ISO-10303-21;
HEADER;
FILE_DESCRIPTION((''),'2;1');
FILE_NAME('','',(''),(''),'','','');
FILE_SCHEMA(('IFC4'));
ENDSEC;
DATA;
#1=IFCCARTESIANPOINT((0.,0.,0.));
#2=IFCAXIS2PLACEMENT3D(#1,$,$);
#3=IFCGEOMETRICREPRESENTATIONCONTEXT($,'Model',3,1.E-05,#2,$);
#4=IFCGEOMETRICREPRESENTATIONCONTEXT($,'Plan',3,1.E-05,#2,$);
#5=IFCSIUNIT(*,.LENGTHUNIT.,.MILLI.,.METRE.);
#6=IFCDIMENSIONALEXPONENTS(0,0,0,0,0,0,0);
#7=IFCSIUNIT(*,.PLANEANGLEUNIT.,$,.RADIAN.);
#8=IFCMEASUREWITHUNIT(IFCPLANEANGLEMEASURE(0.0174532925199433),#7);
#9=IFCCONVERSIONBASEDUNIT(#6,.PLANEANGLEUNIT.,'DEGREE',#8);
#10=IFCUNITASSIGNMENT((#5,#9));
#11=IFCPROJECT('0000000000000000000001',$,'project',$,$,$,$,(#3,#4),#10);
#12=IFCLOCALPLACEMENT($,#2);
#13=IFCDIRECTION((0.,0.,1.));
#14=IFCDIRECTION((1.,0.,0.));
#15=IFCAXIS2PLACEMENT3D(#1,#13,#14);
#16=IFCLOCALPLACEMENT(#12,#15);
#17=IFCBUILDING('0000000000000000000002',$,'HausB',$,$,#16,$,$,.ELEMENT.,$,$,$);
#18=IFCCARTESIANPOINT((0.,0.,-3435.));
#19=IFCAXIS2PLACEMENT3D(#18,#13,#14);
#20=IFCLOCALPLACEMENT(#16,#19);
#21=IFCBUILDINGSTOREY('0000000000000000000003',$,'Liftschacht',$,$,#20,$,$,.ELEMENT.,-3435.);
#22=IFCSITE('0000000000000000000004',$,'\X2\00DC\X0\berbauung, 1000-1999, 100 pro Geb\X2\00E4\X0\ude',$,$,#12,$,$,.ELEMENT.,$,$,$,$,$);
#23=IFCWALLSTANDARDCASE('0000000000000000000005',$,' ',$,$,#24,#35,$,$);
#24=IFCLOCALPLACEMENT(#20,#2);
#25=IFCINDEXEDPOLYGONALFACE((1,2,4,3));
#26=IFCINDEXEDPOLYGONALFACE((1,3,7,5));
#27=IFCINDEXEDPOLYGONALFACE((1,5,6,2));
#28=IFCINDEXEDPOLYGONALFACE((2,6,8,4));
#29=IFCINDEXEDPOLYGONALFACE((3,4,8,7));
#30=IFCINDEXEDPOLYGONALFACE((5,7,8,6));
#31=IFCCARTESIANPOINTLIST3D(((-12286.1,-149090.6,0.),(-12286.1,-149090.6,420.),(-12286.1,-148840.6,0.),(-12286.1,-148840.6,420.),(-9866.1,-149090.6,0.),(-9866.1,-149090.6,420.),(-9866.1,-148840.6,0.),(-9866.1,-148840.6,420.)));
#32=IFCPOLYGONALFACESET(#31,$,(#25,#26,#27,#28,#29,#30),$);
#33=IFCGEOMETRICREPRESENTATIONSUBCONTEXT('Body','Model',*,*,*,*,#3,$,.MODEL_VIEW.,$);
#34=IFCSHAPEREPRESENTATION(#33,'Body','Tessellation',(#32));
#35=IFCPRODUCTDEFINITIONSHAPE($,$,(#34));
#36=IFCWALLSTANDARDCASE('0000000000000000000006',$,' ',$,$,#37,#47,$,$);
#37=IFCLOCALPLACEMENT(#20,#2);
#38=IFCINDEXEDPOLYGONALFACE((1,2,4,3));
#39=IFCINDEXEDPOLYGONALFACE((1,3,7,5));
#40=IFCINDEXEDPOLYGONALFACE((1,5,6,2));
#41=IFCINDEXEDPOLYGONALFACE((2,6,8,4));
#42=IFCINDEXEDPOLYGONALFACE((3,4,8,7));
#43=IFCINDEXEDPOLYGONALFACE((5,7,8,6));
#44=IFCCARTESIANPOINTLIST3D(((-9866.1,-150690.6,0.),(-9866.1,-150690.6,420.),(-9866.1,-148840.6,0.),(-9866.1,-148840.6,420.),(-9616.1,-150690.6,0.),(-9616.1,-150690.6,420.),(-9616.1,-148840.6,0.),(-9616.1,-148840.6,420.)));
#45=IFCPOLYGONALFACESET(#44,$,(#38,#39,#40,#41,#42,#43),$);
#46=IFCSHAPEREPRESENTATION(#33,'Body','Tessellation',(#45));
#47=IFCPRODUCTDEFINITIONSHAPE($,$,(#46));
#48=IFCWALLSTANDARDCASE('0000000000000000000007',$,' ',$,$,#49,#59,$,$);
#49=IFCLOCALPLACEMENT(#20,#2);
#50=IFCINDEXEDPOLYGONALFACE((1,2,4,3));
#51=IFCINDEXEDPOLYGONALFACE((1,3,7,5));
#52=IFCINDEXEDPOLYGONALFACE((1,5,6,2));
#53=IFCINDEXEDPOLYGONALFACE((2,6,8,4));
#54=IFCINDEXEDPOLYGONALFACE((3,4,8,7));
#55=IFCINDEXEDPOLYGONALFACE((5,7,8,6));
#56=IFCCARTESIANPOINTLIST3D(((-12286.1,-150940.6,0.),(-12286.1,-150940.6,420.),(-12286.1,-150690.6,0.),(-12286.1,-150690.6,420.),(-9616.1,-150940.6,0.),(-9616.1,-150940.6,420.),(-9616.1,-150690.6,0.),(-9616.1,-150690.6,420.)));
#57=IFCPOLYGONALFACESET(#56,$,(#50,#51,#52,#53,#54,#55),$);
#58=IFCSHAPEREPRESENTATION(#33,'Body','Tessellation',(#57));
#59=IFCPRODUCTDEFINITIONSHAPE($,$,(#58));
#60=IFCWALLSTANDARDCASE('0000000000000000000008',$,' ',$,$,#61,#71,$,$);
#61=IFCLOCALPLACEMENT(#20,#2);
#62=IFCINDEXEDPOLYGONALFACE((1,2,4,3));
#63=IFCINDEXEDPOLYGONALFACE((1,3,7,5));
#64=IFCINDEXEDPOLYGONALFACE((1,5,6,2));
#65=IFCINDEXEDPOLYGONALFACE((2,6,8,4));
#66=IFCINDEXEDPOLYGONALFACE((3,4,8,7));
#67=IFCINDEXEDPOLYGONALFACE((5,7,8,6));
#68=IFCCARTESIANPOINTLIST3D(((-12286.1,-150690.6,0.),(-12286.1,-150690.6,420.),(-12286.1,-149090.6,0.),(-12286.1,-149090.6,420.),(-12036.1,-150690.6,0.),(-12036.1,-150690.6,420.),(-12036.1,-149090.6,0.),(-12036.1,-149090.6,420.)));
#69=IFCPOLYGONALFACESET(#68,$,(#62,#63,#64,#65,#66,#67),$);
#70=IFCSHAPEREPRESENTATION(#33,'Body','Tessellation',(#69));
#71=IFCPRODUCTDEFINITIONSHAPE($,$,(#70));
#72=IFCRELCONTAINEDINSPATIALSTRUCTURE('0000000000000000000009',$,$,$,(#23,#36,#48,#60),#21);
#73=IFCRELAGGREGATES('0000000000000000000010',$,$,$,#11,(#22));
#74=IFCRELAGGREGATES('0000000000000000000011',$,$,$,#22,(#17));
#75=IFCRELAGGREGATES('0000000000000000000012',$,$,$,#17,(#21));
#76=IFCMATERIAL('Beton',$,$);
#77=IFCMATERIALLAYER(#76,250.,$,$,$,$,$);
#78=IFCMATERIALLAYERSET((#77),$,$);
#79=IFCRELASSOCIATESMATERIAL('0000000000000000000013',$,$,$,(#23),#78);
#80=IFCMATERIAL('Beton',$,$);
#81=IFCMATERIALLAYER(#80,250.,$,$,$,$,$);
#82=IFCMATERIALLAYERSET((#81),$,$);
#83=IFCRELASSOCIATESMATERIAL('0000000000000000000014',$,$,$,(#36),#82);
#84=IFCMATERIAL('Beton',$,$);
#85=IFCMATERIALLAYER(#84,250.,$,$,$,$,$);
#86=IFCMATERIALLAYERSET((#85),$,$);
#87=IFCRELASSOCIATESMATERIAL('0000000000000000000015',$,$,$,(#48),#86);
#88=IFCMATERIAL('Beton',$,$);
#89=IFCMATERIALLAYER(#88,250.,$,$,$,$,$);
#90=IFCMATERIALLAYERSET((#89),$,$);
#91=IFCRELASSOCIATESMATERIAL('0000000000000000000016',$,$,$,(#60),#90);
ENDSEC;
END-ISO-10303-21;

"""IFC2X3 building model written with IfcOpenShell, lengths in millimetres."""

from ifc_helpers import new_model, entity, si_unit, converted_unit, frame, frame_2d, origin, origin_with_axes, place, context, subcontext, project, spatial, rectangle, extrude, material, layer, layer_set, layer_usage, element, save


model = new_model("IFC2X3")

# Units and contexts
model_context = context("Model", 3, precision=1e-05, world=origin())
plan_context = context("Plan", 3, precision=1e-05, world=origin())
body_context = subcontext(model_context, "Body", "Model", "MODEL_VIEW")
ifc_project = project(units=[si_unit("LENGTHUNIT", "METRE", prefix="MILLI"), converted_unit("PLANEANGLEUNIT", "DEGREE", entity("IfcPlaneAngleMeasure", 0.0174532925199433), si_unit("PLANEANGLEUNIT", "RADIAN"), dimensions=[0, 0, 0, 0, 0, 0, 0])], contexts=[model_context, plan_context])

# Site, building, storey
site_placement = place(None, origin())
site = spatial("IfcSite", under=ifc_project, at=site_placement, Name="Überbauung, 1000-1999, 100 pro Gebäude", CompositionType="ELEMENT")
building_placement = place(site_placement, origin_with_axes())
building = spatial("IfcBuilding", under=site, at=building_placement, Name="HausB", CompositionType="ELEMENT")
storey_placement = place(building_placement, frame((0.0, 0.0, -3435.0), z_axis=(0.0, 0.0, 1.0), x_axis=(1.0, 0.0, 0.0)))
storey = spatial("IfcBuildingStorey", under=building, at=storey_placement, Name="Liftschacht", CompositionType="ELEMENT", Elevation=-3435.0)

# Walls
ifc_material_1 = material(Name="Beton")
ifc_layer_1 = layer(ifc_material_1, 250.0)
ifc_layer_set_1 = layer_set([ifc_layer_1])
ifc_layer_usage_1 = layer_usage(ifc_layer_set_1, "AXIS2", "POSITIVE", 0.0)
wall_1_placement = place(storey_placement, frame((-9866.1, -148840.6, 0.0), z_axis=(0.0, 0.0, 1.0), x_axis=(-1.0, 0.0, 0.0)))
element("IfcWallStandardCase", 1, at=wall_1_placement, inside=storey, material=ifc_layer_usage_1, Name=" ", context=body_context, shape_type="SweptSolid", body=[
    extrude(rectangle(XDim=2420.0, YDim=250.0, at=frame_2d((1210.0, 125.0), x_axis=(1.0, 0.0))), origin_with_axes(), (0.0, 0.0, 1.0), 420.0),
])
ifc_material_2 = material(Name="Beton")
ifc_layer_2 = layer(ifc_material_2, 250.0)
ifc_layer_set_2 = layer_set([ifc_layer_2])
ifc_layer_usage_2 = layer_usage(ifc_layer_set_2, "AXIS2", "POSITIVE", 0.0)
wall_2_placement = place(storey_placement, frame((-9616.1, -150690.6, 0.0), z_axis=(0.0, 0.0, 1.0), x_axis=(0.0, 1.0, 0.0)))
element("IfcWallStandardCase", 2, at=wall_2_placement, inside=storey, material=ifc_layer_usage_2, Name=" ", context=body_context, shape_type="SweptSolid", body=[
    extrude(rectangle(XDim=1850.0, YDim=250.0, at=frame_2d((925.0, 125.0), x_axis=(1.0, 0.0))), origin_with_axes(), (0.0, 0.0, 1.0), 420.0),
])
ifc_material_3 = material(Name="Beton")
ifc_layer_3 = layer(ifc_material_3, 250.0)
ifc_layer_set_3 = layer_set([ifc_layer_3])
ifc_layer_usage_3 = layer_usage(ifc_layer_set_3, "AXIS2", "POSITIVE", 0.0)
wall_3_placement = place(storey_placement, frame((-12286.1, -150940.6, 0.0), z_axis=(0.0, 0.0, 1.0), x_axis=(1.0, 0.0, 0.0)))
element("IfcWallStandardCase", 3, at=wall_3_placement, inside=storey, material=ifc_layer_usage_3, Name=" ", context=body_context, shape_type="SweptSolid", body=[
    extrude(rectangle(XDim=2670.0, YDim=250.0, at=frame_2d((1335.0, 125.0), x_axis=(1.0, 0.0))), origin_with_axes(), (0.0, 0.0, 1.0), 420.0),
])
ifc_material_4 = material(Name="Beton")
ifc_layer_4 = layer(ifc_material_4, 250.0)
ifc_layer_set_4 = layer_set([ifc_layer_4])
ifc_layer_usage_4 = layer_usage(ifc_layer_set_4, "AXIS2", "POSITIVE", 0.0)
wall_4_placement = place(storey_placement, frame((-12286.1, -149090.6, 0.0), z_axis=(0.0, 0.0, 1.0), x_axis=(0.0, -1.0, 0.0)))
element("IfcWallStandardCase", 4, at=wall_4_placement, inside=storey, material=ifc_layer_usage_4, Name=" ", context=body_context, shape_type="SweptSolid", body=[
    extrude(rectangle(XDim=1600.0, YDim=250.0, at=frame_2d((800.0, 125.0), x_axis=(1.0, 0.0))), origin_with_axes(), (0.0, 0.0, 1.0), 420.0),
])

save(model, "model.ifc")
